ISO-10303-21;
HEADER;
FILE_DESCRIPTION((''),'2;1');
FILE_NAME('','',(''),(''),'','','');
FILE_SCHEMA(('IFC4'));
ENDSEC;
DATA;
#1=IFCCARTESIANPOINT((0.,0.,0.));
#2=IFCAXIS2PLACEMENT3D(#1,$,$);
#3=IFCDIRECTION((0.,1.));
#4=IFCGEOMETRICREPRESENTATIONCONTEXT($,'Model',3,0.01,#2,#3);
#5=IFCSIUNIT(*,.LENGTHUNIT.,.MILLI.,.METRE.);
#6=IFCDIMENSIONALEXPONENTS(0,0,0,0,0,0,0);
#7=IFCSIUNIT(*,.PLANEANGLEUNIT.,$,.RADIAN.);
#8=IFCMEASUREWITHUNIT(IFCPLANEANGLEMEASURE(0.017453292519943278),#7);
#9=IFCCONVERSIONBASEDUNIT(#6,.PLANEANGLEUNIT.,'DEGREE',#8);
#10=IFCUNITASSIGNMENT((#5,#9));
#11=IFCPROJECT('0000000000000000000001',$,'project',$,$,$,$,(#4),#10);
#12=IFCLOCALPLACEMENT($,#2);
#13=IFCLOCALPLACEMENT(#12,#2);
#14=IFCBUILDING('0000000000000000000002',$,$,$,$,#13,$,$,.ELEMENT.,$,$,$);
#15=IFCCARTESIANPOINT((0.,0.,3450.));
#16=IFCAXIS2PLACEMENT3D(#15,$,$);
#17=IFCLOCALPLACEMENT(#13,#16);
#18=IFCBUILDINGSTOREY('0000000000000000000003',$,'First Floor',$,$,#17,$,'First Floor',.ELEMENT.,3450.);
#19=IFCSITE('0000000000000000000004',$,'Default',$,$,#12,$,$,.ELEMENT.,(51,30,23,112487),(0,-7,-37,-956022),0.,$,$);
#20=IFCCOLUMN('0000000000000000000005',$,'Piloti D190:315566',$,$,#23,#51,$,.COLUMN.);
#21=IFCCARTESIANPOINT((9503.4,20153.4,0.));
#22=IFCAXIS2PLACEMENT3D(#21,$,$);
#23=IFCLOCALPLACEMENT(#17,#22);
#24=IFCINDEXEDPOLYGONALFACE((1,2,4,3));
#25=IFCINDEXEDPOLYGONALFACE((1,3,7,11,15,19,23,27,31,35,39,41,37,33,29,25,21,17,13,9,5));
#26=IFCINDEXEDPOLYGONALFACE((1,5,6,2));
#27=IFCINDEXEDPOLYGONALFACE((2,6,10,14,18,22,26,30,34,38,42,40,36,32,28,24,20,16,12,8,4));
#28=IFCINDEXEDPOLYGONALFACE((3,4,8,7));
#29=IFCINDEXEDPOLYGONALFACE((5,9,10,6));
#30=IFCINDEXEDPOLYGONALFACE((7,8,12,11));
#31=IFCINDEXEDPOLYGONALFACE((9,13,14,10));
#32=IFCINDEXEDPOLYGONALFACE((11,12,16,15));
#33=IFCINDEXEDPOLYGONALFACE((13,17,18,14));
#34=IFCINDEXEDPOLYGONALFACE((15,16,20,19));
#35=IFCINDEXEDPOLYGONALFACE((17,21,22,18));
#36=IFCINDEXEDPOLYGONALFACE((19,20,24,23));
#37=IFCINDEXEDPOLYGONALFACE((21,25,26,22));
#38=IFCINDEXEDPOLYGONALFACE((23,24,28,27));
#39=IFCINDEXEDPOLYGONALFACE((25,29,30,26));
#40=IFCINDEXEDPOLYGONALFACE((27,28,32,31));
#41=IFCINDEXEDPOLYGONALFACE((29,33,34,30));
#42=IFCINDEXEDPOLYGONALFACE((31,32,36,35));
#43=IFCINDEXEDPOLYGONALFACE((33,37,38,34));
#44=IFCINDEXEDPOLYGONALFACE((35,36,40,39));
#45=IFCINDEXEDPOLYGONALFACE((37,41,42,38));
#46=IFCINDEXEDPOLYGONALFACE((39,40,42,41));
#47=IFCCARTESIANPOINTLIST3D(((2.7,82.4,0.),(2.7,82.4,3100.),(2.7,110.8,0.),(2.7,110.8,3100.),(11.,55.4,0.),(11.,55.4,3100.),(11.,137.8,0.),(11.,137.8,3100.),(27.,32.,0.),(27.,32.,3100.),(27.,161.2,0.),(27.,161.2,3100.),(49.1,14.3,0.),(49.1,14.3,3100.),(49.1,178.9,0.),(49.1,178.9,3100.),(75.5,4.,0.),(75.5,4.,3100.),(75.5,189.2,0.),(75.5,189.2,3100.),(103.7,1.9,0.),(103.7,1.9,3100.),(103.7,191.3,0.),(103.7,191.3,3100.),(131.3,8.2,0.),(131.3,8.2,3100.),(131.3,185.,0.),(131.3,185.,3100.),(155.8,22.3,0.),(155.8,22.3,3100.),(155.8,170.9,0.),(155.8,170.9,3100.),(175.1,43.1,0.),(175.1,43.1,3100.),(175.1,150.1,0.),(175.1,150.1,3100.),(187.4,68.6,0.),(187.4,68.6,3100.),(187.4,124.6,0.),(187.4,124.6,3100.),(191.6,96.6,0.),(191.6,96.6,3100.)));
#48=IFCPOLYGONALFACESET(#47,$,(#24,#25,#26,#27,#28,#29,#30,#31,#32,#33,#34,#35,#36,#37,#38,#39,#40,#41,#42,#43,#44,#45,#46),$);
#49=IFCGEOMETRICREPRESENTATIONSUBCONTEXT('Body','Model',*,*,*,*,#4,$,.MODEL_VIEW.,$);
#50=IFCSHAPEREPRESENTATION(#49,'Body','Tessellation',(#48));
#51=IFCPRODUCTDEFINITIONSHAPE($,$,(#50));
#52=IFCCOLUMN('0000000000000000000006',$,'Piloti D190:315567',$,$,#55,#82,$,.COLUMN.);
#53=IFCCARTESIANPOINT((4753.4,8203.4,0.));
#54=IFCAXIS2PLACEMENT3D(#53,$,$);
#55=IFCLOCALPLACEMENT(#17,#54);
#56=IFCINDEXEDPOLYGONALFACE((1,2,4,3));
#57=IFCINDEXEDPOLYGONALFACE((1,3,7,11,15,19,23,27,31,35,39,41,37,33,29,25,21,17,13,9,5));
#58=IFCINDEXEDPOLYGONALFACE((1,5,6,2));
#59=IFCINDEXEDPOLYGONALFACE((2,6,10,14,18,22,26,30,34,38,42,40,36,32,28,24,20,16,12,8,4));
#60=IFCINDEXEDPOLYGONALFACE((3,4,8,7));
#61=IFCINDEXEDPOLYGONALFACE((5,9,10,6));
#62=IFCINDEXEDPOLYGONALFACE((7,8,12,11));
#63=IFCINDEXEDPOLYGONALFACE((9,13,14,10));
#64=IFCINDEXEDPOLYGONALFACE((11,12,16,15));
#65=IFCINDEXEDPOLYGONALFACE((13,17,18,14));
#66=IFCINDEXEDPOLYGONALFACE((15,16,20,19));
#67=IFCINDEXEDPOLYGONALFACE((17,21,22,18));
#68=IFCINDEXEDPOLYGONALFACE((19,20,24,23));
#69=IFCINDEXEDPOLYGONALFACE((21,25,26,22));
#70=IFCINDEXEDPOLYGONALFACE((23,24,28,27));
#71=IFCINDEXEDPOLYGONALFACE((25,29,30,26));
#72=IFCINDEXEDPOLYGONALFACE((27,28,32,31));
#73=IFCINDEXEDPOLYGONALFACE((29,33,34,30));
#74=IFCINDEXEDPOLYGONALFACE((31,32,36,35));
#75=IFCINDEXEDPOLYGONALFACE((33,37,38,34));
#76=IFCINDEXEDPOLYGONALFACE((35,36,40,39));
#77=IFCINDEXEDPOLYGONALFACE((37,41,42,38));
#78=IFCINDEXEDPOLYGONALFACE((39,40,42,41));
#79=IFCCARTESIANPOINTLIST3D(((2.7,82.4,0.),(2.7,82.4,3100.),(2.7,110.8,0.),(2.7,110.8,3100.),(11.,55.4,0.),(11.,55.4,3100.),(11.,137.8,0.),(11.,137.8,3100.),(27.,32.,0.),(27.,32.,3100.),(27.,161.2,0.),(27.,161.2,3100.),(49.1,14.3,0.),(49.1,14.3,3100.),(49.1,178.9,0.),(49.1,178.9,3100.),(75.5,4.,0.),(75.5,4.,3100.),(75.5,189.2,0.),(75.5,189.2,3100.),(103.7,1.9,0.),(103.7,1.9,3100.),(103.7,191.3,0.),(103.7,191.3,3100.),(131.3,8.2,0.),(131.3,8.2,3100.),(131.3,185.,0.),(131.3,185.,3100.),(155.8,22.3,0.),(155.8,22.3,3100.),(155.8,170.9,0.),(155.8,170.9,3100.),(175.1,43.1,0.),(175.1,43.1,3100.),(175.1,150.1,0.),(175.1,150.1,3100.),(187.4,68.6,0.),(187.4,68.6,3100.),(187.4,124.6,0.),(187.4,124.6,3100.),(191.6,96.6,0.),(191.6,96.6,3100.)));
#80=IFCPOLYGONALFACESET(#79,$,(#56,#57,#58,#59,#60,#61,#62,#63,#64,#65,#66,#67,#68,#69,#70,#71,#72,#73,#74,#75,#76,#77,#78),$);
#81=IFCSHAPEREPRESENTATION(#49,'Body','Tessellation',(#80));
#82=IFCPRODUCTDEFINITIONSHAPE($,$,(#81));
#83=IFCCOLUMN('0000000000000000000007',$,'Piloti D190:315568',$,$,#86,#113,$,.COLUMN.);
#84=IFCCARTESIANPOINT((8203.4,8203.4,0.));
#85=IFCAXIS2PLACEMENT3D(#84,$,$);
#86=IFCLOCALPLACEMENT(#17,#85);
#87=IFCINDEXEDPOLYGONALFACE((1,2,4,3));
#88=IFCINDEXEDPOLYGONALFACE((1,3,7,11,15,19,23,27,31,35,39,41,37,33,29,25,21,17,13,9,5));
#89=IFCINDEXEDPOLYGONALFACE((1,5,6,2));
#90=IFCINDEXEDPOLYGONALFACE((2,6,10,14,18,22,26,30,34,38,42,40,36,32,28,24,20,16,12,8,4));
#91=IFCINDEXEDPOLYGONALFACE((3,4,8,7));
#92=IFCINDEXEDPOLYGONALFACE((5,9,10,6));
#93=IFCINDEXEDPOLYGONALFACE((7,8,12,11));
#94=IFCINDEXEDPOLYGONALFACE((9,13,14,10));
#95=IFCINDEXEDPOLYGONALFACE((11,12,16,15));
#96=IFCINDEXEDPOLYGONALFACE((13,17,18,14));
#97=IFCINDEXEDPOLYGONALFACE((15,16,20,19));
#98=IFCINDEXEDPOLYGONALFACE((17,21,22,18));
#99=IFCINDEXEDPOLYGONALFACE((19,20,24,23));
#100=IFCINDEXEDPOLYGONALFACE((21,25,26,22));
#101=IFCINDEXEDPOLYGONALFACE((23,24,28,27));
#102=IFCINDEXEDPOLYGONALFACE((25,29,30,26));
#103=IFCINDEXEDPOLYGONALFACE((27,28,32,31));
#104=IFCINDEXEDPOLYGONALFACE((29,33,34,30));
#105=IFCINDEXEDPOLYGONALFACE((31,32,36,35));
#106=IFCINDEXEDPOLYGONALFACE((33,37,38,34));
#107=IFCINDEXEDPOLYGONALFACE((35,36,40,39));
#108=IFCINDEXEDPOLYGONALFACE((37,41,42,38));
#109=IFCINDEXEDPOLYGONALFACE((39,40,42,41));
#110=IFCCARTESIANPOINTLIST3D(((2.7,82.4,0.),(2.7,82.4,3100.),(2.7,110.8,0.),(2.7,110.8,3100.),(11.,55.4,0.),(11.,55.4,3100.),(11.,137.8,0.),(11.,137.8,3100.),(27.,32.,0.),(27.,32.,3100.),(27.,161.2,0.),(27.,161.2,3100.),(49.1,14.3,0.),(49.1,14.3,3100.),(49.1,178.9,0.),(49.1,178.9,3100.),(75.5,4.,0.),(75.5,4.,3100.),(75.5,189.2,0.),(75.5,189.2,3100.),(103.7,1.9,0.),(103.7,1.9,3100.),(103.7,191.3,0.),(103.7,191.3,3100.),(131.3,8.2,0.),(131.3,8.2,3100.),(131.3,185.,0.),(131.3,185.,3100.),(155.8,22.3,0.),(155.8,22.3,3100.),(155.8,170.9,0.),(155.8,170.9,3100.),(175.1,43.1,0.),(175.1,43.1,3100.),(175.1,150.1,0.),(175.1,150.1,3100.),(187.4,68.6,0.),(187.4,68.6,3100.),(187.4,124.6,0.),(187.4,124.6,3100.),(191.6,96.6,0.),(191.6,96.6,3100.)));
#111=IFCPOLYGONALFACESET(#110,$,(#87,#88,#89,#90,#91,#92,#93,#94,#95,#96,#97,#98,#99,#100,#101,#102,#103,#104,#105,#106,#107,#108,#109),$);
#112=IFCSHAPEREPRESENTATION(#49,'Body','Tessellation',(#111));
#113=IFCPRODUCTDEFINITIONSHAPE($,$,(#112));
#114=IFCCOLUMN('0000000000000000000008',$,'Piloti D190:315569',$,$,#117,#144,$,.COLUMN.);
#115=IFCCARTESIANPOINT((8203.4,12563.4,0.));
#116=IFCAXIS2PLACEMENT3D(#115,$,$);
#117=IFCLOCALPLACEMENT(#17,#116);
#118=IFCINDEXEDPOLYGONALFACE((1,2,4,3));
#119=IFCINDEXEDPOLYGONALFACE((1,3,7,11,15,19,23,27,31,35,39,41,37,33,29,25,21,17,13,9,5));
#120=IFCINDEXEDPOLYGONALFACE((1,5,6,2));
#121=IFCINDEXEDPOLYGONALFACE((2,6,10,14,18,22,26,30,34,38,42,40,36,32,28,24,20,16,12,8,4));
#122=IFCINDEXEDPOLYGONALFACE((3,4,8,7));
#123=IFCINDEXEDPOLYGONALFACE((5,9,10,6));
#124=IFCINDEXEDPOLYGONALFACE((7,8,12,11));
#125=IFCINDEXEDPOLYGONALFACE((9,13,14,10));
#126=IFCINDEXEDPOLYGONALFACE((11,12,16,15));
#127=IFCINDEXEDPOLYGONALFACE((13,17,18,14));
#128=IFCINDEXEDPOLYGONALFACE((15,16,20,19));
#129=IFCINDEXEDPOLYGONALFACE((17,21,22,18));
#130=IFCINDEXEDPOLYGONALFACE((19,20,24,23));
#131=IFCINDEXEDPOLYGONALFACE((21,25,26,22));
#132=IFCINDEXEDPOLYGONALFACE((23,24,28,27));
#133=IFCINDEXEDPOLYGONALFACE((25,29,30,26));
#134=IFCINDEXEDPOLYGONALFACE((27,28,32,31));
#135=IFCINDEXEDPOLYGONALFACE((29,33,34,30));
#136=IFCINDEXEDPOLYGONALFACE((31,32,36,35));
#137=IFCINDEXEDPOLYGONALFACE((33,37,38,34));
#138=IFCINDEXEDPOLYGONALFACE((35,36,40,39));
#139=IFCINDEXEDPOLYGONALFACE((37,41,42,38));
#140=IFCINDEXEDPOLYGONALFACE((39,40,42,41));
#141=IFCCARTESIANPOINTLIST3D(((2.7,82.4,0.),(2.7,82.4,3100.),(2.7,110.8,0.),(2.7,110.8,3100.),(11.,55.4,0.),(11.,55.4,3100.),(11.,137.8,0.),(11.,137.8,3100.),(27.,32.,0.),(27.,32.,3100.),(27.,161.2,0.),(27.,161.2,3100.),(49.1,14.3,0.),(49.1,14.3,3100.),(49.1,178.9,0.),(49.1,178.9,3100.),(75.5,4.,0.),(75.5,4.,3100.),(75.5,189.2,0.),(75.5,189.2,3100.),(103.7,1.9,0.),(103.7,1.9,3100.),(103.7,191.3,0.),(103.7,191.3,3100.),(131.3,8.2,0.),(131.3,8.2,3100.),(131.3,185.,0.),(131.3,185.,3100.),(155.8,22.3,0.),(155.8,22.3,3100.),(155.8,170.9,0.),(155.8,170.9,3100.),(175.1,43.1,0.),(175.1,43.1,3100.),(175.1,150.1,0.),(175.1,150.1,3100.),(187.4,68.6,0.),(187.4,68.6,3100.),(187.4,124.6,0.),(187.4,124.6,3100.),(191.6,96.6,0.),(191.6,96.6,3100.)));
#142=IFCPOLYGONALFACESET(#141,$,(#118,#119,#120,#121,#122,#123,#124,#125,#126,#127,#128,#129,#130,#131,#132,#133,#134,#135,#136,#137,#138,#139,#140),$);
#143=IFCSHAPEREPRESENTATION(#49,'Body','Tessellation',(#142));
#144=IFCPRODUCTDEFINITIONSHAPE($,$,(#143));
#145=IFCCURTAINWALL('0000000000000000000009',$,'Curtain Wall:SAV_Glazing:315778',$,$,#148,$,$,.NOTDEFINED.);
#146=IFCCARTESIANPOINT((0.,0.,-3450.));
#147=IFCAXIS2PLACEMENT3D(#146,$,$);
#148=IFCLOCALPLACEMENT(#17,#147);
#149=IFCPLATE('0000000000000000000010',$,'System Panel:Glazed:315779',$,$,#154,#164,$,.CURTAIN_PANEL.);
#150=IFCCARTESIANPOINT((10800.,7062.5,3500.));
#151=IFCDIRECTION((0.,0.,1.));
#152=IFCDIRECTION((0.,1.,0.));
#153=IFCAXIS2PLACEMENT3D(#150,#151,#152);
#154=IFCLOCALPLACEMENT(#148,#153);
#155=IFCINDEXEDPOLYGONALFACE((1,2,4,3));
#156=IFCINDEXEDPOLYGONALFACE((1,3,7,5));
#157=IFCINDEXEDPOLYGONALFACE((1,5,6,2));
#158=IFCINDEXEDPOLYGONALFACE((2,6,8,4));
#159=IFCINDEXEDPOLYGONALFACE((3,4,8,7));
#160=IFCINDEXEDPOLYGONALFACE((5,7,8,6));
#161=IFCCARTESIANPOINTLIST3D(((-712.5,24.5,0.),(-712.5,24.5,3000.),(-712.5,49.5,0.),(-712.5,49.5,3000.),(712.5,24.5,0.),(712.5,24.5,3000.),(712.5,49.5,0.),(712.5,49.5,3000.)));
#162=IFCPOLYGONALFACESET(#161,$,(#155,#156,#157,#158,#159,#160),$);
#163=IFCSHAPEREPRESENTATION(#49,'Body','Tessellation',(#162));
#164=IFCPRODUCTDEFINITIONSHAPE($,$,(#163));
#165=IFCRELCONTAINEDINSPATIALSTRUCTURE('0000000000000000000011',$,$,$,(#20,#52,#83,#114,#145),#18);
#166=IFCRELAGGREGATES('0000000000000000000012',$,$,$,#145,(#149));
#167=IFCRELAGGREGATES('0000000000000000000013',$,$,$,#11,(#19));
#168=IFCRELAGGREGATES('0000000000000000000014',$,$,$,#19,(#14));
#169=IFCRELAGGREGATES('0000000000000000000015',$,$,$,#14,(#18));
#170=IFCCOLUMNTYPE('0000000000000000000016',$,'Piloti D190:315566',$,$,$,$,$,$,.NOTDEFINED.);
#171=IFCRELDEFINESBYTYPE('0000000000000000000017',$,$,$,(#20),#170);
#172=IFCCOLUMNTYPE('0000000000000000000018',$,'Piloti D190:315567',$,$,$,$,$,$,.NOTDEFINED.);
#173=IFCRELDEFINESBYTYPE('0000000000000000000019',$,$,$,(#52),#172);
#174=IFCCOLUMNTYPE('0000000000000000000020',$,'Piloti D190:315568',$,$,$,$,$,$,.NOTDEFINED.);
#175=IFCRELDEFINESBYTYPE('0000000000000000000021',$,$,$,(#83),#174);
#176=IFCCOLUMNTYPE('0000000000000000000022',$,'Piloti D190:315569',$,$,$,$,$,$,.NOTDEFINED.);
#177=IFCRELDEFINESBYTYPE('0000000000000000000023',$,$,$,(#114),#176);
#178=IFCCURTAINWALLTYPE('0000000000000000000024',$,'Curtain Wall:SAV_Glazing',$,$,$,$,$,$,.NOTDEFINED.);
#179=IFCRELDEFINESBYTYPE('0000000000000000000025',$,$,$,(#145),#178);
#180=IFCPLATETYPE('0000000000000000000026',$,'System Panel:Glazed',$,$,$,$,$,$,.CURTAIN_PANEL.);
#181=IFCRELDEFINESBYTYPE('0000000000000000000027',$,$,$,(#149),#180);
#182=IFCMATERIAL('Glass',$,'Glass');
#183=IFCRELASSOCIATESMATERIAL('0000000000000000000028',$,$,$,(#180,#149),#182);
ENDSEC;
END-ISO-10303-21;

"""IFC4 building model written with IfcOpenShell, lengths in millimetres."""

from ifc_helpers import new_model, entity, si_unit, converted_unit, direction, frame, origin, origin_2d_with_axis, place, context, subcontext, project, spatial, rectangle, circle, extrude, source, transform, mapped, material, type_object, type_shapes, element, aggregate, save


model = new_model("IFC4")

# Units and contexts
model_context = context("Model", 3, precision=0.01, world=origin(), true_north=direction((0.0, 1.0)))
body_context = subcontext(model_context, "Body", "Model", "MODEL_VIEW")
ifc_project = project(units=[si_unit("LENGTHUNIT", "METRE", prefix="MILLI"), converted_unit("PLANEANGLEUNIT", "DEGREE", entity("IfcPlaneAngleMeasure", 0.017453292519943278), si_unit("PLANEANGLEUNIT", "RADIAN"), dimensions=[0, 0, 0, 0, 0, 0, 0])], contexts=[model_context])

# Site, building, storey
site_placement = place(None, origin())
site = spatial("IfcSite", under=ifc_project, at=site_placement, Name="Default", CompositionType="ELEMENT", RefLatitude=(51, 30, 23, 112487), RefLongitude=(0, -7, -37, -956022), RefElevation=0.0)
building_placement = place(site_placement, origin())
building = spatial("IfcBuilding", under=site, at=building_placement, CompositionType="ELEMENT")
storey_placement = place(building_placement, frame((0.0, 0.0, 3450.0)))
storey = spatial("IfcBuildingStorey", under=building, at=storey_placement, Name="First Floor", LongName="First Floor", CompositionType="ELEMENT", Elevation=3450.0)

# Columns
column_type_1 = type_object("IfcColumnType", Name="Piloti D190:315566", PredefinedType="NOTDEFINED")
column_1_placement = place(storey_placement, frame((9503.4, 20153.4, 0.0)))
element("IfcColumn", 1, at=column_1_placement, inside=storey, type_object=column_type_1, Name="Piloti D190:315566", PredefinedType="COLUMN", context=body_context, shape_type="SweptSolid", body=[
    extrude(circle(Radius=95.0, at=origin_2d_with_axis()), frame((96.6, 96.6, 0.0)), (0.0, 0.0, 1.0), 3100.0),
])
column_type_2 = type_object("IfcColumnType", Name="Piloti D190:315567", PredefinedType="NOTDEFINED")
column_2_placement = place(storey_placement, frame((4753.4, 8203.4, 0.0)))
element("IfcColumn", 2, at=column_2_placement, inside=storey, type_object=column_type_2, Name="Piloti D190:315567", PredefinedType="COLUMN", context=body_context, shape_type="SweptSolid", body=[
    extrude(circle(Radius=95.0, at=origin_2d_with_axis()), frame((96.6, 96.6, 0.0)), (0.0, 0.0, 1.0), 3100.0),
])
column_type_3 = type_object("IfcColumnType", Name="Piloti D190:315568", PredefinedType="NOTDEFINED")
column_3_placement = place(storey_placement, frame((8203.4, 8203.4, 0.0)))
element("IfcColumn", 3, at=column_3_placement, inside=storey, type_object=column_type_3, Name="Piloti D190:315568", PredefinedType="COLUMN", context=body_context, shape_type="SweptSolid", body=[
    extrude(circle(Radius=95.0, at=origin_2d_with_axis()), frame((96.6, 96.6, 0.0)), (0.0, 0.0, 1.0), 3100.0),
])
column_type_4 = type_object("IfcColumnType", Name="Piloti D190:315569", PredefinedType="NOTDEFINED")
column_4_placement = place(storey_placement, frame((8203.4, 12563.4, 0.0)))
element("IfcColumn", 4, at=column_4_placement, inside=storey, type_object=column_type_4, Name="Piloti D190:315569", PredefinedType="COLUMN", context=body_context, shape_type="SweptSolid", body=[
    extrude(circle(Radius=95.0, at=origin_2d_with_axis()), frame((96.6, 96.6, 0.0)), (0.0, 0.0, 1.0), 3100.0),
])

# Curtain wall, plate
curtain_wall_type = type_object("IfcCurtainWallType", Name="Curtain Wall:SAV_Glazing", PredefinedType="NOTDEFINED")
curtain_wall_placement = place(storey_placement, frame((0.0, 0.0, -3450.0)))
curtain_wall = element("IfcCurtainWall", 5, at=curtain_wall_placement, inside=storey, type_object=curtain_wall_type, Name="Curtain Wall:SAV_Glazing:315778", PredefinedType="NOTDEFINED")
ifc_material_1 = material(Name="Glass", Category="Glass")
plate_type = type_object("IfcPlateType", Name="System Panel:Glazed", PredefinedType="CURTAIN_PANEL", material=ifc_material_1)
shared_shape_1 = source(origin(), body_context, "Body", "SweptSolid", [
    extrude(rectangle(XDim=25.0, YDim=1425.0, at=origin_2d_with_axis()), frame((0.0, 37.0, 0.0), z_axis=(0.0, 0.0, 1.0), x_axis=(0.0, 1.0, 0.0)), (0.0, 0.0, 1.0), 3000.0),
])
type_shapes(plate_type, [shared_shape_1])
plate_placement = place(curtain_wall_placement, frame((10800.0, 7062.5, 3500.0), z_axis=(0.0, 0.0, 1.0), x_axis=(0.0, 1.0, 0.0)))
plate = element("IfcPlate", 6, at=plate_placement, type_object=plate_type, material=ifc_material_1, Name="System Panel:Glazed:315779", PredefinedType="CURTAIN_PANEL", context=body_context, shape_type="MappedRepresentation", body=[
    mapped(shared_shape_1, transform((0.0, 0.0, 0.0), scale=1.0)),
])
aggregate(curtain_wall, [plate])

save(model, "model.ifc")
